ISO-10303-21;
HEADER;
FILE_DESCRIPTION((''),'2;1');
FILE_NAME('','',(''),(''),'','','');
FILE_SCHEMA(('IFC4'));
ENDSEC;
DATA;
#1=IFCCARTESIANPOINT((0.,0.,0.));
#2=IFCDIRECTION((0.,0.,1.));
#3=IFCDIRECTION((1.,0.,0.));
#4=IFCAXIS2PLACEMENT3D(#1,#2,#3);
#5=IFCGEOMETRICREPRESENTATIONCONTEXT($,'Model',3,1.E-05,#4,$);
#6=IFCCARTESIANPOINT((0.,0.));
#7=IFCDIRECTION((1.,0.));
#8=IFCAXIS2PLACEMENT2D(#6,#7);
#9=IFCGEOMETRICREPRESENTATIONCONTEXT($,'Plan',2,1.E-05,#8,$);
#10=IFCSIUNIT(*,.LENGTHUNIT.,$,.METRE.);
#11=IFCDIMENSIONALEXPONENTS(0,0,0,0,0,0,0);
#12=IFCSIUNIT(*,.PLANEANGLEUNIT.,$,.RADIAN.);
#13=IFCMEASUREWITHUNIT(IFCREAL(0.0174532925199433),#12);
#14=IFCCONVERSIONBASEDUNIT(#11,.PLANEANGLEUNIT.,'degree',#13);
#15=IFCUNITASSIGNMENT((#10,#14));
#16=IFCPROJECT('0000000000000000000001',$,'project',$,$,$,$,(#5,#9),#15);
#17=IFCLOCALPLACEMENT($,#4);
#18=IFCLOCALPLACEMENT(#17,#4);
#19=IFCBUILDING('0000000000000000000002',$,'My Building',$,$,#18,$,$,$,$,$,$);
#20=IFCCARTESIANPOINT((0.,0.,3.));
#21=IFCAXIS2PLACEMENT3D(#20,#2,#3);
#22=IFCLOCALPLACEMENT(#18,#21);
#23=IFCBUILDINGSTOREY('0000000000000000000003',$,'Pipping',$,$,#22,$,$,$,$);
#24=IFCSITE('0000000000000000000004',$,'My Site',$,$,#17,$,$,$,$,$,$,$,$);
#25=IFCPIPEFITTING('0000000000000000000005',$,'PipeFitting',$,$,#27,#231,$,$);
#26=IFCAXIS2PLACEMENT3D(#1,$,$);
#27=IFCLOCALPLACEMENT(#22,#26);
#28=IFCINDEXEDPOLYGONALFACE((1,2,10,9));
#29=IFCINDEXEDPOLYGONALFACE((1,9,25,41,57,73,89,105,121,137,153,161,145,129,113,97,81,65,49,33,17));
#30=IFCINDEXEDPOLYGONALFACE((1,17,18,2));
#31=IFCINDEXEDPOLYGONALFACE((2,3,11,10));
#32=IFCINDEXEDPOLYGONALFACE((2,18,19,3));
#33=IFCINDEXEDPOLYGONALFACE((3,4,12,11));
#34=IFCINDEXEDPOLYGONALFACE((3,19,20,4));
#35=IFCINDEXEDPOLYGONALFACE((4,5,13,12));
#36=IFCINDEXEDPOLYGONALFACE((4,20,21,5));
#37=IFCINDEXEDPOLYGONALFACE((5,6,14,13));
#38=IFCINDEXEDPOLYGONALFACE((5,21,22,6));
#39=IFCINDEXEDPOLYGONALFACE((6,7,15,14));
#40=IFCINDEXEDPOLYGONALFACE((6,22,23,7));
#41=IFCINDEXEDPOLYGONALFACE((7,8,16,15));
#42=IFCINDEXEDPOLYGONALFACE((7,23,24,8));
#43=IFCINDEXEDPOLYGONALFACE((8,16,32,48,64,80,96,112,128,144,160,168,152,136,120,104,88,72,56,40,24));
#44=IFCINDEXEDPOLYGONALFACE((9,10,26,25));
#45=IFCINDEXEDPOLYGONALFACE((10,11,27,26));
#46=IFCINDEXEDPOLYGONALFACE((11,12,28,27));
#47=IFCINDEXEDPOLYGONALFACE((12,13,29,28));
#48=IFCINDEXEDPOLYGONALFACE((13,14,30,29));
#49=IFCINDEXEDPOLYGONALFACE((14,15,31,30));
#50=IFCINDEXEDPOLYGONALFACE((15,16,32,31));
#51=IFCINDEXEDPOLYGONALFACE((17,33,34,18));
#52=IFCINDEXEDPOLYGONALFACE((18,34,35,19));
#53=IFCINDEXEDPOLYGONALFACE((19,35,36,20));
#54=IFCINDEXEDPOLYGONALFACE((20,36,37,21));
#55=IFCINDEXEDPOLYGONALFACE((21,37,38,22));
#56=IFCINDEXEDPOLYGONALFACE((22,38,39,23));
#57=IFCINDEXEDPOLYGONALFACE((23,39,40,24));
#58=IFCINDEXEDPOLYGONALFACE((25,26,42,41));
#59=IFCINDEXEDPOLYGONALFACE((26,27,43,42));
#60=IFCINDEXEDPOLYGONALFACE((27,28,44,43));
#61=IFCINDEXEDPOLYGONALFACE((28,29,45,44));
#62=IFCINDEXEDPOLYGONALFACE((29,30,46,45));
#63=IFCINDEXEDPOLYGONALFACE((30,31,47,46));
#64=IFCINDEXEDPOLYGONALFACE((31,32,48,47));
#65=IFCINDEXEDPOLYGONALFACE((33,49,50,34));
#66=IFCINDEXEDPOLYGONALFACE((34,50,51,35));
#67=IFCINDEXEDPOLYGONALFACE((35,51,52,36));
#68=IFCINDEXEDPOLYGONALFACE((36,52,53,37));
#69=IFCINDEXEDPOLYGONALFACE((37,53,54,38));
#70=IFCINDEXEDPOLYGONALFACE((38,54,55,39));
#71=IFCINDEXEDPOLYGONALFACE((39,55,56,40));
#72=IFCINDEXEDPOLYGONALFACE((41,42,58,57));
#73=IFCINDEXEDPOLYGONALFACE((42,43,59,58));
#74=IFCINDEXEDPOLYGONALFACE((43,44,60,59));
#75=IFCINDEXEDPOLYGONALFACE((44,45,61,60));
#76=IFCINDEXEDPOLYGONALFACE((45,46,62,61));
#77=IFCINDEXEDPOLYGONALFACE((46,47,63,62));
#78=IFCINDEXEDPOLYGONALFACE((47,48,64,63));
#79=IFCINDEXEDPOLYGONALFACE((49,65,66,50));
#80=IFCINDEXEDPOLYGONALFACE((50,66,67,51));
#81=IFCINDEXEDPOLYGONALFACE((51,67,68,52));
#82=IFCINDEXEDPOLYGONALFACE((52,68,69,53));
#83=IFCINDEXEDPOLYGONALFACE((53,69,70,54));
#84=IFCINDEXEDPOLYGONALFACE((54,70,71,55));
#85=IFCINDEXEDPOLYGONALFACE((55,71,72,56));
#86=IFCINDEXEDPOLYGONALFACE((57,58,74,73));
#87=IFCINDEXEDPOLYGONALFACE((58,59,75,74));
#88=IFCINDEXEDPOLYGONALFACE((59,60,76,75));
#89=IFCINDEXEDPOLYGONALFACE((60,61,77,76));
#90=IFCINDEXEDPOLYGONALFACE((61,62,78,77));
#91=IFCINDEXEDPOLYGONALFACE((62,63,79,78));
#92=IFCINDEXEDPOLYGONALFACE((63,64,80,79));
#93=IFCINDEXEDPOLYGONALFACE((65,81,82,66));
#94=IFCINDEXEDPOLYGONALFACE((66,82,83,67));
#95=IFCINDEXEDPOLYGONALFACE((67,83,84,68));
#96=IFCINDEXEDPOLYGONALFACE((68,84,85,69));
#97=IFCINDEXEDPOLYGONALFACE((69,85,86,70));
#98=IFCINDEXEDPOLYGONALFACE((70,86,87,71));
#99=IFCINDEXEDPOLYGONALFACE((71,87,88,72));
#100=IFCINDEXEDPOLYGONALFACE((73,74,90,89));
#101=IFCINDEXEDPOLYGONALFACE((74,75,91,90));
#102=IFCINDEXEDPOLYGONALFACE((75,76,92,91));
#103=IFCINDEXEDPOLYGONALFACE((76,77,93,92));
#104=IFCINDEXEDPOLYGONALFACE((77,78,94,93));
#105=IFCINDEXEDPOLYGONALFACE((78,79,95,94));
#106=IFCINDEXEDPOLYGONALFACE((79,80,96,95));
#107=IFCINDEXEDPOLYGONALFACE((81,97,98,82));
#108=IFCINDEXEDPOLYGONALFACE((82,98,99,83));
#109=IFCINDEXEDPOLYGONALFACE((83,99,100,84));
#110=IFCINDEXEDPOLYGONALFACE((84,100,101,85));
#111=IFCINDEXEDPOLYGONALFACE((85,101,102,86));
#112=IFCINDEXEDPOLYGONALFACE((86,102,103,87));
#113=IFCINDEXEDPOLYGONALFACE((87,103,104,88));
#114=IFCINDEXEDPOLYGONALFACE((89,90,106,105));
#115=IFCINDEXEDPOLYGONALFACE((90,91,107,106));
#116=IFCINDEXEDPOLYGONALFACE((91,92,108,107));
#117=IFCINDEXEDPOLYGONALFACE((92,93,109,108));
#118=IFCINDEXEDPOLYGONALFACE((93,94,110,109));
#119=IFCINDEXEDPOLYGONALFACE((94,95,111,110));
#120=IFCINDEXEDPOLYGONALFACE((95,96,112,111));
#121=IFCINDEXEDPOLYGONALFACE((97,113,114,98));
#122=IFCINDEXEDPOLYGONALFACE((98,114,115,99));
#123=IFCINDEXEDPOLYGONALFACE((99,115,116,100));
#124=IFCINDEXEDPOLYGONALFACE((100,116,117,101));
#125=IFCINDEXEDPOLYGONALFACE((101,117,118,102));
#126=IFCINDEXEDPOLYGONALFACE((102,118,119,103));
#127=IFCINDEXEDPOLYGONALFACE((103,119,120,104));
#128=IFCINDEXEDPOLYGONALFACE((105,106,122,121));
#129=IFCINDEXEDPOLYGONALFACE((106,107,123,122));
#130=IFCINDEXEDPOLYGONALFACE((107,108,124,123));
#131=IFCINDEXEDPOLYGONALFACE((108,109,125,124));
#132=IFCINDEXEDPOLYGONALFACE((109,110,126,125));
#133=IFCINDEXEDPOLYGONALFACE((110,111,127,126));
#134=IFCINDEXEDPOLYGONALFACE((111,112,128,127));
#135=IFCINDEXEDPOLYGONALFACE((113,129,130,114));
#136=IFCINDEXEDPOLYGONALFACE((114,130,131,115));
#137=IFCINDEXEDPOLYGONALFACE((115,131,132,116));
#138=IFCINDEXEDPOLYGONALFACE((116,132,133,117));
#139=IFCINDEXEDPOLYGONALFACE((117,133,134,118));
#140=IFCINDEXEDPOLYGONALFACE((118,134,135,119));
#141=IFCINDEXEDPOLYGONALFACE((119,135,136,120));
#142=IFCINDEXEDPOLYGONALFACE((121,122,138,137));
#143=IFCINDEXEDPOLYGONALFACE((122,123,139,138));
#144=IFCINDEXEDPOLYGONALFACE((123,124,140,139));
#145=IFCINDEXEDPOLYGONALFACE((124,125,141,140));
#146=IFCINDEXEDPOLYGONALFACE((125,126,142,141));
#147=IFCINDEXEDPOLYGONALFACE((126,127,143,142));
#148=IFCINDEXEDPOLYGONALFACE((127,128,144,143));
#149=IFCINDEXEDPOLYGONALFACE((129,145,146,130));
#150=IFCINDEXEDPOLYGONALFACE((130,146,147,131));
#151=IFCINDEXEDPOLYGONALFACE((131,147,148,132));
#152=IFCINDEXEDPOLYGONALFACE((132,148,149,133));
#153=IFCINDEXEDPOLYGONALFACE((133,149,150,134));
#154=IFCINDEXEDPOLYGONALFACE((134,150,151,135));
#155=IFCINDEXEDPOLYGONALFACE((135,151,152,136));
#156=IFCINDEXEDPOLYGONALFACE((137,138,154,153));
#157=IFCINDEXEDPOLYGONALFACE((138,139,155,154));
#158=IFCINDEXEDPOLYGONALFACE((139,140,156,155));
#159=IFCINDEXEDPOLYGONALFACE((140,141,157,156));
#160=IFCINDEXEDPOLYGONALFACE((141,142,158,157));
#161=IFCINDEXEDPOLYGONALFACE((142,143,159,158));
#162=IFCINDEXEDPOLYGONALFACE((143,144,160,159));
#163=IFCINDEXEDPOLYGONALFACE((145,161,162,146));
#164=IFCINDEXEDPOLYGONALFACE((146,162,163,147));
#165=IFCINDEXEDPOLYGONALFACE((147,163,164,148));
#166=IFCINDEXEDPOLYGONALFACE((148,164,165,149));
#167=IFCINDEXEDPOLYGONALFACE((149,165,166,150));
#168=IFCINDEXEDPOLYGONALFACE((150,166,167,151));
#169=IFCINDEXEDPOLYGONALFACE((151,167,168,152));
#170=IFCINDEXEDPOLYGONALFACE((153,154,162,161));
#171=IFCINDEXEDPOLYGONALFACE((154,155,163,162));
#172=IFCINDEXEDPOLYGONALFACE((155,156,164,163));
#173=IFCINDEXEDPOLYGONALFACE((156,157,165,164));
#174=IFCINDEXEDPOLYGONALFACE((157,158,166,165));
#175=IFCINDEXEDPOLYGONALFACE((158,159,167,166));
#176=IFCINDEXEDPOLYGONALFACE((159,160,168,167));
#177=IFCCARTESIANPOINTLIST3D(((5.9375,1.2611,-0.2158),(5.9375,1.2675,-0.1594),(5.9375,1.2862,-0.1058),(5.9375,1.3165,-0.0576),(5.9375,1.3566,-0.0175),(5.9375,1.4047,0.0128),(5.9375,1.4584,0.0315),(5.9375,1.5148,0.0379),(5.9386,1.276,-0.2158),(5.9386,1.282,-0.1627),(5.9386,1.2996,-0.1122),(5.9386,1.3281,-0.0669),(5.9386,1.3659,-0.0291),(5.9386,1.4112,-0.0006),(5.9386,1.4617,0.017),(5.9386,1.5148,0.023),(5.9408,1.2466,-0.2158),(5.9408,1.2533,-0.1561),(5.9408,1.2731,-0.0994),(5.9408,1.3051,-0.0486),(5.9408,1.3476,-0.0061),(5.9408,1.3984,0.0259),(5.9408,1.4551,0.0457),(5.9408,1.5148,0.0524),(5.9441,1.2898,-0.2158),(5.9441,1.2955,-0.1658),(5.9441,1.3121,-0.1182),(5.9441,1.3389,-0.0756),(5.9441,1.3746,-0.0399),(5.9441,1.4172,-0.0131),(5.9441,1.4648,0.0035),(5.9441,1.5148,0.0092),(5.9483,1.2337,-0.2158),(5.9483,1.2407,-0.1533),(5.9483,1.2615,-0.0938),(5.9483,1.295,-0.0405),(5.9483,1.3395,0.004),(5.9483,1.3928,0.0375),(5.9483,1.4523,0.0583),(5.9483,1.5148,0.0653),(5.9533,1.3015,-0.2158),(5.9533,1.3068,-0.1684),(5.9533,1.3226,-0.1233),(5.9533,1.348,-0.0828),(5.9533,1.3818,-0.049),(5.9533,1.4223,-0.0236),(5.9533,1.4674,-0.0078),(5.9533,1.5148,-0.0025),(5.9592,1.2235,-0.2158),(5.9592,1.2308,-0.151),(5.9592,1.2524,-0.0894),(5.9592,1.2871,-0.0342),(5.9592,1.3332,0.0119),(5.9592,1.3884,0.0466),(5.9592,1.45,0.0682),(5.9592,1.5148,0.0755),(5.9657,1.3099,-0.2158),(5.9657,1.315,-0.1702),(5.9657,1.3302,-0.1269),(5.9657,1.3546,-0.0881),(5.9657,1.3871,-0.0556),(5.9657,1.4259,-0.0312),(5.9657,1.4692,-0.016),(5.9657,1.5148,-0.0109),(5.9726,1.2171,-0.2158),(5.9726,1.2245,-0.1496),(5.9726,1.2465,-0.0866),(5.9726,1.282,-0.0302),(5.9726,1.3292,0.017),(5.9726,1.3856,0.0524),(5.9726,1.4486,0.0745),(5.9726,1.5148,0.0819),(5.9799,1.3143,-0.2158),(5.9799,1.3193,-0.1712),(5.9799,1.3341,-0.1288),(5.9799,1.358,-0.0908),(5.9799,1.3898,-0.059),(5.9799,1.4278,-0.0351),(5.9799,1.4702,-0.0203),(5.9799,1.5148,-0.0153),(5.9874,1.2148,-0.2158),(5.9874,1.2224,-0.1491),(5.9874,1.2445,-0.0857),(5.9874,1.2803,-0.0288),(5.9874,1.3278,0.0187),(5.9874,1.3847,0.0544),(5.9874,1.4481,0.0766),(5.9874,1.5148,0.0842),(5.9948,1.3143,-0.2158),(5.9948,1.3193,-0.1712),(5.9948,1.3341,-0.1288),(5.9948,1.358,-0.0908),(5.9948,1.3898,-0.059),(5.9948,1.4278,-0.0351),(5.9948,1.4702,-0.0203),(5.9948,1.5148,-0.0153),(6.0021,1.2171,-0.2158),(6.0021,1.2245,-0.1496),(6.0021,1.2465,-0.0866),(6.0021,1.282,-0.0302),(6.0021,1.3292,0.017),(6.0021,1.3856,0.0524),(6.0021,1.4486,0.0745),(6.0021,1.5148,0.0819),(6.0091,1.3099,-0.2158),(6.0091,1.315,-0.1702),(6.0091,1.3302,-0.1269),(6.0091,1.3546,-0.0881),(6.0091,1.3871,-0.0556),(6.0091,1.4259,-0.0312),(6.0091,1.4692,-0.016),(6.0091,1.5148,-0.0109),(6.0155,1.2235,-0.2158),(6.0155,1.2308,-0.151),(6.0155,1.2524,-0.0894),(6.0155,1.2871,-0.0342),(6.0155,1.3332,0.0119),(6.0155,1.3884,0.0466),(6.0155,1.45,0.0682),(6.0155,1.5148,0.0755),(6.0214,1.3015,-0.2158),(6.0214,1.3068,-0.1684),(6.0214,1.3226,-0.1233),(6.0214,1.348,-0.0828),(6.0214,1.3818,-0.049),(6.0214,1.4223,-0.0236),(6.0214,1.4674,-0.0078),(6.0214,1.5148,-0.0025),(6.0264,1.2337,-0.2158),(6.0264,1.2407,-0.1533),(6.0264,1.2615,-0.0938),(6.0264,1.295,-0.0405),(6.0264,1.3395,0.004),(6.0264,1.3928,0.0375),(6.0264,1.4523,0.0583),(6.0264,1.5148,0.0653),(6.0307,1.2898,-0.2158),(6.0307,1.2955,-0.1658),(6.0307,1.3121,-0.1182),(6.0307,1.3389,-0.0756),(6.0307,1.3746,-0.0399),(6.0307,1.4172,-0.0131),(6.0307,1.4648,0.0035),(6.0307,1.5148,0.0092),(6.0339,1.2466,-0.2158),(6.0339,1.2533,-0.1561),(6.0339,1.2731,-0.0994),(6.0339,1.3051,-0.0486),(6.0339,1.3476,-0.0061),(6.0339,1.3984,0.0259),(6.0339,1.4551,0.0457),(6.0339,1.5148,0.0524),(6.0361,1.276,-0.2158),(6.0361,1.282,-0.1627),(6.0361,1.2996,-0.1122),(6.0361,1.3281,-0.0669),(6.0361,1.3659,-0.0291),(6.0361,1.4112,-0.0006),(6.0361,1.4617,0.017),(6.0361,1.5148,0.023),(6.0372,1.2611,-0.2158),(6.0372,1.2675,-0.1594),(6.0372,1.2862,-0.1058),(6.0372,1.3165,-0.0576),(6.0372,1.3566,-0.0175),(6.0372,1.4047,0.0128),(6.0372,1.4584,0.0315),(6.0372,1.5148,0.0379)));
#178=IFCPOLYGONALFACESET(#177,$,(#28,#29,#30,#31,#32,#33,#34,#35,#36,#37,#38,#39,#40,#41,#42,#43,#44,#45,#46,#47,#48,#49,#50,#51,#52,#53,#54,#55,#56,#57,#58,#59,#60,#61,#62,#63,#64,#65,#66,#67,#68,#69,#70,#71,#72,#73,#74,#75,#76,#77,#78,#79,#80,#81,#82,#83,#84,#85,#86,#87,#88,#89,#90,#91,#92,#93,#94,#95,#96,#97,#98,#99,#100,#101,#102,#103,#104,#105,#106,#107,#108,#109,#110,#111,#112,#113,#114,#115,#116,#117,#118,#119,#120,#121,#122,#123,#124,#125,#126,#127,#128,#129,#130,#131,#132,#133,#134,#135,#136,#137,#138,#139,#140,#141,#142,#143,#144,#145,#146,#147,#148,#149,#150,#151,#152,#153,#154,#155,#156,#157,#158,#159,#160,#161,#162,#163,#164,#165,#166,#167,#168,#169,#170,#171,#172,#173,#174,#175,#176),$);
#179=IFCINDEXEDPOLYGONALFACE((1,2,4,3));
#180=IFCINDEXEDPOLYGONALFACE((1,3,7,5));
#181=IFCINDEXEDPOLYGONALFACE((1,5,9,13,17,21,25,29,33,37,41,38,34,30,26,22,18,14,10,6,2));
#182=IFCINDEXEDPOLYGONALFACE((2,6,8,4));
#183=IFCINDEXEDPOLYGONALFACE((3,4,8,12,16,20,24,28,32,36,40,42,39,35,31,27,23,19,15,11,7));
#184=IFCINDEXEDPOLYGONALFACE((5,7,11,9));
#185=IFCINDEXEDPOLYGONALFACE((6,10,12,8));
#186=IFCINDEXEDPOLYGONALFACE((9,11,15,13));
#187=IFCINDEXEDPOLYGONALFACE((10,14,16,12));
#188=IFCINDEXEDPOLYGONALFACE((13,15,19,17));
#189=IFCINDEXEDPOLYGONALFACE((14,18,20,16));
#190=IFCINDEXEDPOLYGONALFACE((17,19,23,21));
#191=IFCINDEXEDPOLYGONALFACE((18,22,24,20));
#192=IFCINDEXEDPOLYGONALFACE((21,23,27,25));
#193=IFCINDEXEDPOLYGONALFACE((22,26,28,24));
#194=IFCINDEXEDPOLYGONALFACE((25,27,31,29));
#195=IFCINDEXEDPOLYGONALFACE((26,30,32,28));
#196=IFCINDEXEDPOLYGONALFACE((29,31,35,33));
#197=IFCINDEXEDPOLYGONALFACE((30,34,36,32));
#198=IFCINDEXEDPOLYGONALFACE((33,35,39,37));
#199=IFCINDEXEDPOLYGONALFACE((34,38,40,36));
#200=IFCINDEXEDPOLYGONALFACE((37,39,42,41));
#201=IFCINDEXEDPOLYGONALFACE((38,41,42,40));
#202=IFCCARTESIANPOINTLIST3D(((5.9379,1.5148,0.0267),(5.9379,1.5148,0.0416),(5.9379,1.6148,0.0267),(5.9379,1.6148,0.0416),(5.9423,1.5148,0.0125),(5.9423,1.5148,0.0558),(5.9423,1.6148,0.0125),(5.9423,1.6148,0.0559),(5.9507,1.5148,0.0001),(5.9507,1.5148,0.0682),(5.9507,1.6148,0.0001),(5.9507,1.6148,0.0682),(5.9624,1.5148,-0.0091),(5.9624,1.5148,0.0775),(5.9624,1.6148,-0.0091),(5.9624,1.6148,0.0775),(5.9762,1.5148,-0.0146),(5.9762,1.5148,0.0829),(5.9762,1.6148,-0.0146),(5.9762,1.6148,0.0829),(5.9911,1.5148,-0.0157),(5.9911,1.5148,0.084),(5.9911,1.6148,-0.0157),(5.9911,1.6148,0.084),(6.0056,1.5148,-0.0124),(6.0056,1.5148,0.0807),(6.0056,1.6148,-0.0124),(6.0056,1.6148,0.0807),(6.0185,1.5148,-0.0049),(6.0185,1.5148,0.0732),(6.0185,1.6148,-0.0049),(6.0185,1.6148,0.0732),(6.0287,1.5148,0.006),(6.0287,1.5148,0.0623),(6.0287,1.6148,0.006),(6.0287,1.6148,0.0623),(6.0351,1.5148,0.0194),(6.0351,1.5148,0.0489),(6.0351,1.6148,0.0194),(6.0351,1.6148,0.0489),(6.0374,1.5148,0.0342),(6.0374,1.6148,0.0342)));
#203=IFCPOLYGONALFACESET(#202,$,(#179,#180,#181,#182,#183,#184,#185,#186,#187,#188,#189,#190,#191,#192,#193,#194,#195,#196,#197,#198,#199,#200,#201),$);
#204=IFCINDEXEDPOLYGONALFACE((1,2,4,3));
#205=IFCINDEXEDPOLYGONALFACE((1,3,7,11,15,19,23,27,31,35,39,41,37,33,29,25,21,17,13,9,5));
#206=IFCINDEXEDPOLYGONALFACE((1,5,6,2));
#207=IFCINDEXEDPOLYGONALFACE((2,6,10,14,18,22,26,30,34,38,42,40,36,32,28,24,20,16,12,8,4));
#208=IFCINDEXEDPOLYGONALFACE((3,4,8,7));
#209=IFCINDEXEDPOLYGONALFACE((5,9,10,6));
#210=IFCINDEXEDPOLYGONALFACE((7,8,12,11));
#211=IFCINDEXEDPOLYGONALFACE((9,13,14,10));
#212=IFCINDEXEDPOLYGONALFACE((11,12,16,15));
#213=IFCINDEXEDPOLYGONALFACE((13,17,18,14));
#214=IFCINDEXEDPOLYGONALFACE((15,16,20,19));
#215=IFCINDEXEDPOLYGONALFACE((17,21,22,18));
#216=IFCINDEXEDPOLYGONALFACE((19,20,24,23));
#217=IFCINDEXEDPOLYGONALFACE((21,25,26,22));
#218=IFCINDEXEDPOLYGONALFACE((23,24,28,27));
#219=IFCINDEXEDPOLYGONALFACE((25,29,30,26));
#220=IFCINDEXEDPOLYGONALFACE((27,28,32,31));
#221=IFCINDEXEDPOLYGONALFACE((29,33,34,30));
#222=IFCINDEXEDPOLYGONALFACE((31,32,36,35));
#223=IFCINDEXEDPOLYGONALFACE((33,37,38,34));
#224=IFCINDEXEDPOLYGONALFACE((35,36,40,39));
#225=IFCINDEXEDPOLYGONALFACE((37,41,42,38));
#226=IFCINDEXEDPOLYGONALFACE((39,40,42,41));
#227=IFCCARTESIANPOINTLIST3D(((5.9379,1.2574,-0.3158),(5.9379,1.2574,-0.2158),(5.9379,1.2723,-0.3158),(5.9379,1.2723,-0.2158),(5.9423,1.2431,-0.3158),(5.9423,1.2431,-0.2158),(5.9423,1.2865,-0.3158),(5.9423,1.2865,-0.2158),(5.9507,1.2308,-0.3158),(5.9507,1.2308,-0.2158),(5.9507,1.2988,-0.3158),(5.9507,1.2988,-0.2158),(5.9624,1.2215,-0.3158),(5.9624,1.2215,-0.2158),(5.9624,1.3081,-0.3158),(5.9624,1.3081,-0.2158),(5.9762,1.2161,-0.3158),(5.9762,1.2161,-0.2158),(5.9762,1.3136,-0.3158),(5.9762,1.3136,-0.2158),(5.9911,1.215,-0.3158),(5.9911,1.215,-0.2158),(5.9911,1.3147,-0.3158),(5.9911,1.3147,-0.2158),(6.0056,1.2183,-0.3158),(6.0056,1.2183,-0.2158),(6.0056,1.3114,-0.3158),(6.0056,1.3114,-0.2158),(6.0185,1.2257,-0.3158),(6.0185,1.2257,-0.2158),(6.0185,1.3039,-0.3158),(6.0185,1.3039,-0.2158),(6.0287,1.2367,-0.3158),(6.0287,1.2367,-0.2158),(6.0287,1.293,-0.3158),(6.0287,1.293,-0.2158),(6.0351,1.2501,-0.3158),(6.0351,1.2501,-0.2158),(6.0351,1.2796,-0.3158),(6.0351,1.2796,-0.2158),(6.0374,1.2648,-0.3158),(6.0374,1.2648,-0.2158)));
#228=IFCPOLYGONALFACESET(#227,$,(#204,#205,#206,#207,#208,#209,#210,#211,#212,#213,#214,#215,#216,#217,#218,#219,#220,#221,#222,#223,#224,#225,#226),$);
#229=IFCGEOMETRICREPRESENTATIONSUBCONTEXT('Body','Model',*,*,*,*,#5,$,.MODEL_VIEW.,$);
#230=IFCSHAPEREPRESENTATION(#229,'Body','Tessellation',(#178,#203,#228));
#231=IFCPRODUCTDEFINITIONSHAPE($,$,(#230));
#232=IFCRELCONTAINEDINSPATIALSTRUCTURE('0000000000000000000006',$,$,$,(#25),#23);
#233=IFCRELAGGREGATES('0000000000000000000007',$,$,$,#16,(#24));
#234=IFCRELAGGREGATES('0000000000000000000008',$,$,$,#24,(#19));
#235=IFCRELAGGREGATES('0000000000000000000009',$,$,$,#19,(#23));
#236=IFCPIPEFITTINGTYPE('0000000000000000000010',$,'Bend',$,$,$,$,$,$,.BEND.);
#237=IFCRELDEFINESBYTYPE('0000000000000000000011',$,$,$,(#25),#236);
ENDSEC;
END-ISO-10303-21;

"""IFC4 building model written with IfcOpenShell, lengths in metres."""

from ifc_helpers import new_model, entity, si_unit, converted_unit, frame, origin_with_axes, origin_2d_with_axis, place, context, subcontext, project, spatial, circle, extrude, source, transform, mapped, type_object, type_shapes, element, save


model = new_model("IFC4")

# Units and contexts
model_context = context("Model", 3, precision=1e-05, world=origin_with_axes())
plan_context = context("Plan", 2, precision=1e-05, world=origin_2d_with_axis())
body_context = subcontext(model_context, "Body", "Model", "MODEL_VIEW")
ifc_project = project(units=[si_unit("LENGTHUNIT", "METRE"), converted_unit("PLANEANGLEUNIT", "degree", entity("IfcReal", 0.0174532925199433), si_unit("PLANEANGLEUNIT", "RADIAN"), dimensions=[0, 0, 0, 0, 0, 0, 0])], contexts=[model_context, plan_context])

# Site, building, storey
site_placement = place(None, origin_with_axes())
site = spatial("IfcSite", under=ifc_project, at=site_placement, Name="My Site")
building_placement = place(site_placement, origin_with_axes())
building = spatial("IfcBuilding", under=site, at=building_placement, Name="My Building")
storey_placement = place(building_placement, frame((0.0, 0.0, 3.0), z_axis=(0.0, 0.0, 1.0), x_axis=(1.0, 0.0, 0.0)))
storey = spatial("IfcBuildingStorey", under=building, at=storey_placement, Name="Pipping")

# Pipe fitting
pipe_fitting_type_1 = type_object("IfcPipeFittingType", Name="Bend", PredefinedType="BEND")
shared_shape_1 = source(origin_with_axes(), body_context, "Body", "SolidModel", [
    entity("IfcSweptDiskSolid", entity("IfcIndexedPolyCurve", entity("IfcCartesianPointList3D", [[0.0, 0.0, 0.1], [0.0, -0.0732, 0.2768], [0.0, -0.25, 0.35]]), [entity("IfcArcIndex", [1, 2, 3])]), 0.05),
    extrude(circle(Radius=0.05), origin_with_axes(), (0.0, 0.0, 1.0), 0.1),
    extrude(circle(Radius=0.05), frame((0.0, -0.25, 0.35), z_axis=(0.0, -1.0, 0.000004), x_axis=(1.0, 0.0, 0.0)), (0.0, 0.0, 1.0), 0.1),
])
type_shapes(pipe_fitting_type_1, [shared_shape_1])
for number, where, z_axis, x_axis, name in (
    (1, (5.9874, 1.6148, 0.0342), (0.0, -1.0, -0.000004), (1.0, 0.0, 0.0), "PipeFitting"),
):
    element("IfcPipeFitting", number, at=place(storey_placement, frame(where, z_axis=z_axis, x_axis=x_axis)), inside=storey, type_object=pipe_fitting_type_1, Name=name, context=body_context, shape_type="MappedRepresentation", body=[
        mapped(shared_shape_1, transform((0.0, 0.0, 0.0), x_axis=(1.0, 0.0, 0.0), y_axis=(0.0, 1.0, 0.0), z_axis=(0.0, 0.0, 1.0), scale=1.0)),
    ])

save(model, "model.ifc")
